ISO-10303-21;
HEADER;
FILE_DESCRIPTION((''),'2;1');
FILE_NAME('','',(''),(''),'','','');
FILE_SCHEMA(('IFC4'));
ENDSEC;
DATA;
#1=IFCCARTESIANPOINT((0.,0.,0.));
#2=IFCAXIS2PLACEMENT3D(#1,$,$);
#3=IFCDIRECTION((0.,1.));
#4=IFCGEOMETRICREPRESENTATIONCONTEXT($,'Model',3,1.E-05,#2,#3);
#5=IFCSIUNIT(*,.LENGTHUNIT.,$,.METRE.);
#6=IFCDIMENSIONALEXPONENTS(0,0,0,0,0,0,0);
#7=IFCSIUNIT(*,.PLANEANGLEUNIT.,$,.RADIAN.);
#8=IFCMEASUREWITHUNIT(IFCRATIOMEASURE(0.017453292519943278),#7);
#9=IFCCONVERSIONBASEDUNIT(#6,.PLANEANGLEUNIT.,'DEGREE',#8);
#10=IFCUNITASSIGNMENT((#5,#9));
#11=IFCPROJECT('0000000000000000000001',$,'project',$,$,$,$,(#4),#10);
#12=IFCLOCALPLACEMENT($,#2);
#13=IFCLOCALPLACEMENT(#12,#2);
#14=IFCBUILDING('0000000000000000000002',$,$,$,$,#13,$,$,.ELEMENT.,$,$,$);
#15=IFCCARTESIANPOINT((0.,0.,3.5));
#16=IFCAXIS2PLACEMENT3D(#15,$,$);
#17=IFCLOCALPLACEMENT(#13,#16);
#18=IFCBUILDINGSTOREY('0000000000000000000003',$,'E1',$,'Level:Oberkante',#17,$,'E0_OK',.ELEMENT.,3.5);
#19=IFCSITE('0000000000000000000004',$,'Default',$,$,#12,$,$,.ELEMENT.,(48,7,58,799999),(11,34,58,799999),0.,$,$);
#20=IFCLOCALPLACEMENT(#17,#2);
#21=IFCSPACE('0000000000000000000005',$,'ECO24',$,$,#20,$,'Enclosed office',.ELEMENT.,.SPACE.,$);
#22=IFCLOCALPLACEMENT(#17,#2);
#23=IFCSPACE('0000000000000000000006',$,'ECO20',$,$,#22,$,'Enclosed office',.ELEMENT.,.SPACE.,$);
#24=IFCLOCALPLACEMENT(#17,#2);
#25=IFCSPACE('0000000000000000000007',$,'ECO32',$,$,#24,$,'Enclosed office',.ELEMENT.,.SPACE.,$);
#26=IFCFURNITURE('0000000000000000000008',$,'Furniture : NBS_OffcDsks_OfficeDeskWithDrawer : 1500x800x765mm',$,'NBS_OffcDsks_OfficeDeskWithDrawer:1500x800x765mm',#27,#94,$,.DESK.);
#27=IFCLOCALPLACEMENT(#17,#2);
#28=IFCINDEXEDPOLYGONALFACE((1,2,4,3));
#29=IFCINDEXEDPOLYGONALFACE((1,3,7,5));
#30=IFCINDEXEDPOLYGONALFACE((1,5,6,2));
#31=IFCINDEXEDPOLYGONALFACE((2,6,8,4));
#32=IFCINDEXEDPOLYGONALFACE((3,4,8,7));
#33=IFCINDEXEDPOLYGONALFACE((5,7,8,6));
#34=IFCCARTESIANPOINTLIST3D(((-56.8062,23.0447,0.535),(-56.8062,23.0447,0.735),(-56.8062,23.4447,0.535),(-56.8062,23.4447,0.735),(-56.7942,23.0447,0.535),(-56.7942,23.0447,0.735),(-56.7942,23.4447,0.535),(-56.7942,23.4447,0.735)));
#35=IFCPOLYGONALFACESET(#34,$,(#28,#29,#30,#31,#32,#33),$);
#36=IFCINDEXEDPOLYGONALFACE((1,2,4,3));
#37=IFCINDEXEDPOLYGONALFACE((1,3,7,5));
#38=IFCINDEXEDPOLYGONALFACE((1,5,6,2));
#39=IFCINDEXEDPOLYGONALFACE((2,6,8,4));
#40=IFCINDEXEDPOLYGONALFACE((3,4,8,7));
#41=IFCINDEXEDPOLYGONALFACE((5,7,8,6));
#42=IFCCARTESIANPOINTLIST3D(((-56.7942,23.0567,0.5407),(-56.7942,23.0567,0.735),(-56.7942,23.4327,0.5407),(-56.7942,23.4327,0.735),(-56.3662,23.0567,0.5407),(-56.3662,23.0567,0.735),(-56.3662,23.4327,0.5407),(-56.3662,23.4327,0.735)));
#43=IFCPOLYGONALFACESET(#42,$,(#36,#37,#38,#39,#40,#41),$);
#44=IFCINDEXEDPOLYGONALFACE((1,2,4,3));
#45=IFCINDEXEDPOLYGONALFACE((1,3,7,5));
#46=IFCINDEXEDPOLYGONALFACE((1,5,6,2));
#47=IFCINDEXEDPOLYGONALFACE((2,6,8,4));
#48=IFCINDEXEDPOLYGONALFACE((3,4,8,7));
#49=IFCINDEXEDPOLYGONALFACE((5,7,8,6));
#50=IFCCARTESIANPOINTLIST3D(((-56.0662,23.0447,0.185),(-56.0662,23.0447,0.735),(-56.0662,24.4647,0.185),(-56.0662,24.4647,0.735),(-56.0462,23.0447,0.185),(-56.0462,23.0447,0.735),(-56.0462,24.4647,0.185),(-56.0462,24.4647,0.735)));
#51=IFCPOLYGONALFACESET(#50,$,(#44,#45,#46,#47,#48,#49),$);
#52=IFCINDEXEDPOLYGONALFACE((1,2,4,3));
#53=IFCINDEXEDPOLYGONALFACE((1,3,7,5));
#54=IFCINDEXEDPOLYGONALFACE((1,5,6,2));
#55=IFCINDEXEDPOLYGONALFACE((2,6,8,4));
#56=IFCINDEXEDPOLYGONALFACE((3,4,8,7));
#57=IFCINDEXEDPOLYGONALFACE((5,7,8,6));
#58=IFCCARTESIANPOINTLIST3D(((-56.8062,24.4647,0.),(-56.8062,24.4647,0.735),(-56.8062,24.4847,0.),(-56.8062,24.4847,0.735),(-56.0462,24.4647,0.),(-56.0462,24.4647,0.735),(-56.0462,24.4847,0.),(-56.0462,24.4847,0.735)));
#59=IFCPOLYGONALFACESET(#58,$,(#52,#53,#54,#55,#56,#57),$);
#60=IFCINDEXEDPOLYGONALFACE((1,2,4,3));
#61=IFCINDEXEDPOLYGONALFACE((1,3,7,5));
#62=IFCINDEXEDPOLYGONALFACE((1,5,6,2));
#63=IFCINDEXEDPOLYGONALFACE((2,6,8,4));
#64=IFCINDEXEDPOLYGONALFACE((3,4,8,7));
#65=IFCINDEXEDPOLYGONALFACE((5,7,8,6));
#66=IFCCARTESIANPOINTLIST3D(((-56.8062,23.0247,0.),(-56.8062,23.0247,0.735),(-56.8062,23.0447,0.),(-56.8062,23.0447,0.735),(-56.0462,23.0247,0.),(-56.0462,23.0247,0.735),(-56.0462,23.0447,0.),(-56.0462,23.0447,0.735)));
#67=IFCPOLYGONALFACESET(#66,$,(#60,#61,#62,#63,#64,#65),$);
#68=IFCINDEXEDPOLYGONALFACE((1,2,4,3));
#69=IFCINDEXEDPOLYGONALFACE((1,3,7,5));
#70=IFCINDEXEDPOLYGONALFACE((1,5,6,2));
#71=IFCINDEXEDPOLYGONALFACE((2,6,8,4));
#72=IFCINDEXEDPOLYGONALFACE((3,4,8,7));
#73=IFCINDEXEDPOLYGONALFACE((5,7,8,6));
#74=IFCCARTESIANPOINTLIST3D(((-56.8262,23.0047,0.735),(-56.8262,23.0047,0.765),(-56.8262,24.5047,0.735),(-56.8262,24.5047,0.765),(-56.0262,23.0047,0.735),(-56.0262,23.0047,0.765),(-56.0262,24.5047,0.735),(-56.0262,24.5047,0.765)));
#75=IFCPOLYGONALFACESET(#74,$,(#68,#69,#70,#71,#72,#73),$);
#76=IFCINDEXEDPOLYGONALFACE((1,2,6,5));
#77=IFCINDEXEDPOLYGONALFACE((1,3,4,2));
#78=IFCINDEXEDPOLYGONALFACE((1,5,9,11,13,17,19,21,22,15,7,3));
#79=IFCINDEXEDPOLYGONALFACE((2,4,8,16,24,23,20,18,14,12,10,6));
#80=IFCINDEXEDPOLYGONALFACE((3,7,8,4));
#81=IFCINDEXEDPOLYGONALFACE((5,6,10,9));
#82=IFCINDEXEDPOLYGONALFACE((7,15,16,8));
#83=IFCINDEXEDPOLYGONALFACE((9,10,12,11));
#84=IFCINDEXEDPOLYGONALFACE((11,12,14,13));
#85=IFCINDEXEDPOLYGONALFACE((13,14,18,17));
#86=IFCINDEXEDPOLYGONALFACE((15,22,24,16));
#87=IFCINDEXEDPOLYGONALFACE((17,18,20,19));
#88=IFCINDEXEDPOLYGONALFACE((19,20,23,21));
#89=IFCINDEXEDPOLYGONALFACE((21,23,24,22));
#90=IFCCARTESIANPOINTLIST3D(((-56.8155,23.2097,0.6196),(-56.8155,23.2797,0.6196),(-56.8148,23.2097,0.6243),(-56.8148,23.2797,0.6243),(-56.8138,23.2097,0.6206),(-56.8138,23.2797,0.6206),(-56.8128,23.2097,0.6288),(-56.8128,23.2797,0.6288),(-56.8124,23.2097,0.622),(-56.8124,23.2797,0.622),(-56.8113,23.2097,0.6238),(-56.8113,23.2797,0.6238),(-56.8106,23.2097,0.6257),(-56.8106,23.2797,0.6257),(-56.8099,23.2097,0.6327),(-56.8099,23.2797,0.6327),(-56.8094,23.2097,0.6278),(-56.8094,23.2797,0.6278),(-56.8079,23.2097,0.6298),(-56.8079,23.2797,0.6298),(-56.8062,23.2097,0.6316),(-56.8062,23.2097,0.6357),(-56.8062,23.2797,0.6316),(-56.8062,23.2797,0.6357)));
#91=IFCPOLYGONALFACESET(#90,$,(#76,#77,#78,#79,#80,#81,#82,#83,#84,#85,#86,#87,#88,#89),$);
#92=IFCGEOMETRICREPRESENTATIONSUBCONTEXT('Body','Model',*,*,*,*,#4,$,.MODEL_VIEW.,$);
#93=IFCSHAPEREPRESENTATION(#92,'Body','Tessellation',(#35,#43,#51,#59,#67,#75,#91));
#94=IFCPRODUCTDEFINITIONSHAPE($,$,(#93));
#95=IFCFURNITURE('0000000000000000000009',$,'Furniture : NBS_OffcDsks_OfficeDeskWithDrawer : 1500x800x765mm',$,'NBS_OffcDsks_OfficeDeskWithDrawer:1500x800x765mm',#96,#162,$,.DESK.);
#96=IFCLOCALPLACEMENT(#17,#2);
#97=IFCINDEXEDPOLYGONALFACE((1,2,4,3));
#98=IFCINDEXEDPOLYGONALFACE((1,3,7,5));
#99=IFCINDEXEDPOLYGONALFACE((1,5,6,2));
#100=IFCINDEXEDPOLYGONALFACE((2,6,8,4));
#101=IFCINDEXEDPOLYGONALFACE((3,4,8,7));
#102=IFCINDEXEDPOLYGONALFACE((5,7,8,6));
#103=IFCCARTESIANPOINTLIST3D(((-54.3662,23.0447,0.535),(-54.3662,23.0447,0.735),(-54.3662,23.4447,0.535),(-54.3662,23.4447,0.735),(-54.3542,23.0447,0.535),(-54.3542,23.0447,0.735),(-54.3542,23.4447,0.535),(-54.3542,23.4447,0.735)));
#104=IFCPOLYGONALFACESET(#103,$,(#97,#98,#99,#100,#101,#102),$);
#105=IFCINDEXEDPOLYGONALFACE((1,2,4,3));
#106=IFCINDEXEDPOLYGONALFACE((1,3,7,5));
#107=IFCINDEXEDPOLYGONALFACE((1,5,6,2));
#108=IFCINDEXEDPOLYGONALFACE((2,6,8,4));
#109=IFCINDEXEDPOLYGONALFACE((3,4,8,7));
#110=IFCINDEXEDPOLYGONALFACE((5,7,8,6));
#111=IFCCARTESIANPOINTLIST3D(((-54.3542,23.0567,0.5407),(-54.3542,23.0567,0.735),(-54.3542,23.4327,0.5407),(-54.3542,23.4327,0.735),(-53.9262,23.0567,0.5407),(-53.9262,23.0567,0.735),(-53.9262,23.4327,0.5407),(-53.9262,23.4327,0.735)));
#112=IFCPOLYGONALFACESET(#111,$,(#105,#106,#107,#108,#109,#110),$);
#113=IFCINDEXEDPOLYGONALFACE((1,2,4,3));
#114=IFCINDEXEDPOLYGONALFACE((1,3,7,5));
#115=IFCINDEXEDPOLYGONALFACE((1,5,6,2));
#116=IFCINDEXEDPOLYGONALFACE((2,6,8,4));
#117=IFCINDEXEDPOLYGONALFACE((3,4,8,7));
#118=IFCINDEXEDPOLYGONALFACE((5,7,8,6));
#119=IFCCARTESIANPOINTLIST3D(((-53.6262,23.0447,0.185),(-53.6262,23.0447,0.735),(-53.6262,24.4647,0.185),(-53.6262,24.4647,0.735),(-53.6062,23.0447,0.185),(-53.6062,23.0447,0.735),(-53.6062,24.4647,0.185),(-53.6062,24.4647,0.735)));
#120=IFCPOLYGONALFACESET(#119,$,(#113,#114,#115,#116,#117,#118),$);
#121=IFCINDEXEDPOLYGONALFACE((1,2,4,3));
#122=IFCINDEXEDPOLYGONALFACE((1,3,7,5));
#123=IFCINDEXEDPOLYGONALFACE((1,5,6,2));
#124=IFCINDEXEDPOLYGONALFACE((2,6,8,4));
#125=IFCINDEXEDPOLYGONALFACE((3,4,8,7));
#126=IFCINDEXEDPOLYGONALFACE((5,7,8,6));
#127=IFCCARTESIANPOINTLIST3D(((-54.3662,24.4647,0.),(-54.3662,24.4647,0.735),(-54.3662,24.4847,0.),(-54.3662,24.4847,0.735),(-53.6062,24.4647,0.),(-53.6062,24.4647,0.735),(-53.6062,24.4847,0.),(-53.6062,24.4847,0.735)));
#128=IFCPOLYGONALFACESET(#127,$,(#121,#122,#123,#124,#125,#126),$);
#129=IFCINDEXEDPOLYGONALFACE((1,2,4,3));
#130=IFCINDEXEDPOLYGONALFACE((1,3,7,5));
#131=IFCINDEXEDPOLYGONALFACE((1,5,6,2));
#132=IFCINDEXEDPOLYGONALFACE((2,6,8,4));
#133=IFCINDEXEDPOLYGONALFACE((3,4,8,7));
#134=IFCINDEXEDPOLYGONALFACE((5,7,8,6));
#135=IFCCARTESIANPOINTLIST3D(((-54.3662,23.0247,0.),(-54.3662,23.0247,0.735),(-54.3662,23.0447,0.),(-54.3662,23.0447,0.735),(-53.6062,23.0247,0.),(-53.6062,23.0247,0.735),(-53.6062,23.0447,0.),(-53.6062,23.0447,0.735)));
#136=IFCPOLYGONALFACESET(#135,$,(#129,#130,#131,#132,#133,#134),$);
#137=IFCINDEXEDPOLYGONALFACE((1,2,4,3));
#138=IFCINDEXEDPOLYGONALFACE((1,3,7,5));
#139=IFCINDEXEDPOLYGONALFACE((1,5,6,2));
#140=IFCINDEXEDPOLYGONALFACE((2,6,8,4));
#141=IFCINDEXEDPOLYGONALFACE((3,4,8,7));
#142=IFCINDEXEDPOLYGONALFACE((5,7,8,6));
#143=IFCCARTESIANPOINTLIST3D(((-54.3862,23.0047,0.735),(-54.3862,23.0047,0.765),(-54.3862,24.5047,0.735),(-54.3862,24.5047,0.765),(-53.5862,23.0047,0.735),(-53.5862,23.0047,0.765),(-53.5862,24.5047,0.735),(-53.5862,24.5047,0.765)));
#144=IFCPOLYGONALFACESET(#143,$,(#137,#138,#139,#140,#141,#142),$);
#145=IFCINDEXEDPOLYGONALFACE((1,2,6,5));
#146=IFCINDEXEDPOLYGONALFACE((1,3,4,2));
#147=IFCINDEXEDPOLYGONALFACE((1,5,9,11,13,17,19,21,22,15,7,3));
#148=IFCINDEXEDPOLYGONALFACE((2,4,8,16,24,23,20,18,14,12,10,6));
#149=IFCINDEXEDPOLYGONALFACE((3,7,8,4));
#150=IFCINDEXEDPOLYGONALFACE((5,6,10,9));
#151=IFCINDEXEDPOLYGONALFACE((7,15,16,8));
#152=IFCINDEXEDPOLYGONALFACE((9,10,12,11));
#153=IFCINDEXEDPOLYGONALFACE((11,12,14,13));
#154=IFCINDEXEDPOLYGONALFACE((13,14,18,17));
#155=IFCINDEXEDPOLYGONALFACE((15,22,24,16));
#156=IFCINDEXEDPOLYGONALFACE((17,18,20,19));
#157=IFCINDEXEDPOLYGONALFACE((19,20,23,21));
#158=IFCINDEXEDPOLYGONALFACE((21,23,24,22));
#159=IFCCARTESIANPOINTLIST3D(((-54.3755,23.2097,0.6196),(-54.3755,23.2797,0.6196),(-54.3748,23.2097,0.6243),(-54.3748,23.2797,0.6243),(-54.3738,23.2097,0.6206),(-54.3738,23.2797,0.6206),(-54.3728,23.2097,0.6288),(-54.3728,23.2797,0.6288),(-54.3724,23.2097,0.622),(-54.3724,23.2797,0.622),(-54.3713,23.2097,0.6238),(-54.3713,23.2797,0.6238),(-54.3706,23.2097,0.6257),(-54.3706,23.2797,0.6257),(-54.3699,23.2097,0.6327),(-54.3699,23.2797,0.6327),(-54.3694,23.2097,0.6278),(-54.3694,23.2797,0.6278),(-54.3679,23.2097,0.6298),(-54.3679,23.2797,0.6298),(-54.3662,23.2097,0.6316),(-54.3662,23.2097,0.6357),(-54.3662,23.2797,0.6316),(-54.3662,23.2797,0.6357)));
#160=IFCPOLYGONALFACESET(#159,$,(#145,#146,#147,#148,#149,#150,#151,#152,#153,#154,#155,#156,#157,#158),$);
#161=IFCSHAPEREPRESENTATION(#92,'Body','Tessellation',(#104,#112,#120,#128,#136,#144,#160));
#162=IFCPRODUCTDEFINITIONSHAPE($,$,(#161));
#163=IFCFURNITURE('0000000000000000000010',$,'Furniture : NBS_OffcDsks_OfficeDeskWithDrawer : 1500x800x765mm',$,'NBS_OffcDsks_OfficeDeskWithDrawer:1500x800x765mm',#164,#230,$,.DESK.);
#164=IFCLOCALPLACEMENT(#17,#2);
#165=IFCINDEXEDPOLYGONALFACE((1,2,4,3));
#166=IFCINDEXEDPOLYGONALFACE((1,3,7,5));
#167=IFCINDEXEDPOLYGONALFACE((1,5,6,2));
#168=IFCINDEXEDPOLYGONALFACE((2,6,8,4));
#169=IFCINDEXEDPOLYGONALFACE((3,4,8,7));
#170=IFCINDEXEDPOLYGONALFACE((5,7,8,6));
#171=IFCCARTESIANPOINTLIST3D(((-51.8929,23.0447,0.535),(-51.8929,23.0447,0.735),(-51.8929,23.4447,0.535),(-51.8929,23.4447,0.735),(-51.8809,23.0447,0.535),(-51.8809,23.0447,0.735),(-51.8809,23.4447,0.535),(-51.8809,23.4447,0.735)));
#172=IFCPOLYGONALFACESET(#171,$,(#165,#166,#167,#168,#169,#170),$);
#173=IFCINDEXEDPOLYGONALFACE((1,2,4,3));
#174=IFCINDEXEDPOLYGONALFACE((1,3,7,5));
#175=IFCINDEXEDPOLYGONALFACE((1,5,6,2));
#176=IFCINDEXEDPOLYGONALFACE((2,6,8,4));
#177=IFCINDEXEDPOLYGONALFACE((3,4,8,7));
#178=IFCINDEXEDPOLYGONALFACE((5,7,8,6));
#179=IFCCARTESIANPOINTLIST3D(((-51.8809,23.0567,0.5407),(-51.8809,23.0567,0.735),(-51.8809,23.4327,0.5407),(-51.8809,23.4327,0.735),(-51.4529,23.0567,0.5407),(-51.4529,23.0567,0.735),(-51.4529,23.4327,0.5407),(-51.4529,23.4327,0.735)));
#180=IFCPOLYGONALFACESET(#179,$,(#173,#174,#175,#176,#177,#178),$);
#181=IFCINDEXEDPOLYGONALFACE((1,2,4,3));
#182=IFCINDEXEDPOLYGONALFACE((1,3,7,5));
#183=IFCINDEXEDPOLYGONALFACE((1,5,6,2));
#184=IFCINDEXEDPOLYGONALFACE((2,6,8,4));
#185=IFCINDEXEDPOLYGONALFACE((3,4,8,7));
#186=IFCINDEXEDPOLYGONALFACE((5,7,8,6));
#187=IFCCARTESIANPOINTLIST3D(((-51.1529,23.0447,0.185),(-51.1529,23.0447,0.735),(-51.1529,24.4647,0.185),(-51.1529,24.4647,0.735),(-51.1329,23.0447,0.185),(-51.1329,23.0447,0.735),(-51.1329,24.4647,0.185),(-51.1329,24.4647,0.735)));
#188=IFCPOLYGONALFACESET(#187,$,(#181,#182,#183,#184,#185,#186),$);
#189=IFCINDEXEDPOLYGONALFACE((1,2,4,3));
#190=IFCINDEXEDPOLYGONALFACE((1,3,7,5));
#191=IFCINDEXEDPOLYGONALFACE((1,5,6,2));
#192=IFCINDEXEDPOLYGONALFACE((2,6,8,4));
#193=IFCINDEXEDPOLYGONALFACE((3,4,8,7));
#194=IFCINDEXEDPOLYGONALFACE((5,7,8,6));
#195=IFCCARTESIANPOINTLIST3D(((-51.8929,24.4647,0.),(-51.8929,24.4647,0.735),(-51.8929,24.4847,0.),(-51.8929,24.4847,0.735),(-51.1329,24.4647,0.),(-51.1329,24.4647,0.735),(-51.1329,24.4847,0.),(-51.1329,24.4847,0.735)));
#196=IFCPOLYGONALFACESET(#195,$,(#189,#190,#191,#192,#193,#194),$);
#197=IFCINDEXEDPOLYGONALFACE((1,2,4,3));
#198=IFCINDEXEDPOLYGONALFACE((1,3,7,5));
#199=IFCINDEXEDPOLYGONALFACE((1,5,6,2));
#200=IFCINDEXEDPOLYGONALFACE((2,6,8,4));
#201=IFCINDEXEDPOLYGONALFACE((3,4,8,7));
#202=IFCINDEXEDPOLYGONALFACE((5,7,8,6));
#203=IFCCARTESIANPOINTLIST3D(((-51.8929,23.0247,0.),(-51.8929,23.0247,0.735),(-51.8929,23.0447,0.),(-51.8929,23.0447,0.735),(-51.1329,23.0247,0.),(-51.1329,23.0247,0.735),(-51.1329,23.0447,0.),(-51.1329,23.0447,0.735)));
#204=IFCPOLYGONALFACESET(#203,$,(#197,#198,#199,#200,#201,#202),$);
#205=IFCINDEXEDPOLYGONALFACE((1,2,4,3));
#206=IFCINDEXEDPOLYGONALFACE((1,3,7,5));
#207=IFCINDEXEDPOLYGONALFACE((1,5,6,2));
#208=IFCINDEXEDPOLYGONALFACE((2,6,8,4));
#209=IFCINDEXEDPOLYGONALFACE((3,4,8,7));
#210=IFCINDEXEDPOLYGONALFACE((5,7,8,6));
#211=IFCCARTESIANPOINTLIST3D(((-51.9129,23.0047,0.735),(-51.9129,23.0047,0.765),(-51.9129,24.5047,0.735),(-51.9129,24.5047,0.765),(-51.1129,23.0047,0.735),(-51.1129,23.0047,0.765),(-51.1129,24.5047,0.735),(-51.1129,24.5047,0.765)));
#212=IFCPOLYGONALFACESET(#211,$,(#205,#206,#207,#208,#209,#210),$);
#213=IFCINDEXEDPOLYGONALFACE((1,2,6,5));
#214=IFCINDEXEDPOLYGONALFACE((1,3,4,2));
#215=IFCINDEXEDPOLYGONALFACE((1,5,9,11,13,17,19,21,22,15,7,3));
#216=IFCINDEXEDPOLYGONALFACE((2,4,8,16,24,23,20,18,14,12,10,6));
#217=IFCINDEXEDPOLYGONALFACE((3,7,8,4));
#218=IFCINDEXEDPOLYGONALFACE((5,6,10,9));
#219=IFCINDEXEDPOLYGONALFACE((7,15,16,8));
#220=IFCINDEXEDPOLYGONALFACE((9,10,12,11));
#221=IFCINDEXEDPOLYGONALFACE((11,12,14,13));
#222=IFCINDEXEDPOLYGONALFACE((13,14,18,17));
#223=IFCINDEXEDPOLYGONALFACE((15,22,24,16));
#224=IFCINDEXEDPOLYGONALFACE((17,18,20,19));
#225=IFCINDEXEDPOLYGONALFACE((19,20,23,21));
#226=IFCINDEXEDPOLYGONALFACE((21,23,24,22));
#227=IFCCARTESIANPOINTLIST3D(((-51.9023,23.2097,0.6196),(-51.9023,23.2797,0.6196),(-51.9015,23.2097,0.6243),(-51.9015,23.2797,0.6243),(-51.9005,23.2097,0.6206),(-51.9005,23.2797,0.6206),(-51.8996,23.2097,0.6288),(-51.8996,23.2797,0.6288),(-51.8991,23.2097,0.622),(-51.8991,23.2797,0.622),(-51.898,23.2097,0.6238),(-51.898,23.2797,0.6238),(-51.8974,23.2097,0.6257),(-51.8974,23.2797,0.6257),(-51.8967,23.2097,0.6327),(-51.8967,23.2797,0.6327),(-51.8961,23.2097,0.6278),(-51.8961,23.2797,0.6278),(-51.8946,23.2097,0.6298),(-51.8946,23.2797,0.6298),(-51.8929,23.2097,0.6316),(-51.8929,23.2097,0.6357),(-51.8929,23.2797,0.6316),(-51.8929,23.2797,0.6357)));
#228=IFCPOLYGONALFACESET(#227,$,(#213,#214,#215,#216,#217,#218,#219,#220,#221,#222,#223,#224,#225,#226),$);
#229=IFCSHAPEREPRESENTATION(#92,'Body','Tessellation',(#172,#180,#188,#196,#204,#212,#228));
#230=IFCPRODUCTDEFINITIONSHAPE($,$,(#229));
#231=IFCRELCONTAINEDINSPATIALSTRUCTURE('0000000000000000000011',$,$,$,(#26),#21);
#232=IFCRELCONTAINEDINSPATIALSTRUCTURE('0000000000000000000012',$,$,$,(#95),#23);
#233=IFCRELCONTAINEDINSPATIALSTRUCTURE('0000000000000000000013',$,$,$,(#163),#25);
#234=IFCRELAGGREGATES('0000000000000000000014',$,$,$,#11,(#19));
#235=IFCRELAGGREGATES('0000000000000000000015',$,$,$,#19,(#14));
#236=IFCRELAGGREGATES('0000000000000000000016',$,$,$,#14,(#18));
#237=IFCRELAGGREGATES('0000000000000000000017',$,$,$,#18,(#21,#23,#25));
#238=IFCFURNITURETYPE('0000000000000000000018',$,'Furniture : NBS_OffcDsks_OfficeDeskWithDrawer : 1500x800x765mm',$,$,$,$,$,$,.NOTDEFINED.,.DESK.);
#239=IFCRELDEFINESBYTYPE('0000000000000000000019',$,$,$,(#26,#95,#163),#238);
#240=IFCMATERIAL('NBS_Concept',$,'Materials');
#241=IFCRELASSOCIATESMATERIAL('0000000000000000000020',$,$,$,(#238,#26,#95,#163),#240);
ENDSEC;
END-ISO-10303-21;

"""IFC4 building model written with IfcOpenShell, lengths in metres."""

from ifc_helpers import new_model, entity, si_unit, converted_unit, direction, frame, origin, place, context, subcontext, project, spatial, line, arc, indexed_curve, outline, extrude, source, transform, mapped, material, type_object, type_shapes, element, save


model = new_model("IFC4")

# Units and contexts
model_context = context("Model", 3, precision=1e-05, world=origin(), true_north=direction((0.0, 1.0)))
body_context = subcontext(model_context, "Body", "Model", "MODEL_VIEW")
ifc_project = project(units=[si_unit("LENGTHUNIT", "METRE"), converted_unit("PLANEANGLEUNIT", "DEGREE", entity("IfcRatioMeasure", 0.017453292519943278), si_unit("PLANEANGLEUNIT", "RADIAN"), dimensions=[0, 0, 0, 0, 0, 0, 0])], contexts=[model_context])

# Site, building, storey
site_placement = place(None, origin())
site = spatial("IfcSite", under=ifc_project, at=site_placement, Name="Default", CompositionType="ELEMENT", RefLatitude=(48, 7, 58, 799999), RefLongitude=(11, 34, 58, 799999), RefElevation=0.0)
building_placement = place(site_placement, origin())
building = spatial("IfcBuilding", under=site, at=building_placement, CompositionType="ELEMENT")
storey_placement = place(building_placement, frame((0.0, 0.0, 3.5)))
storey = spatial("IfcBuildingStorey", under=building, at=storey_placement, Name="E1", ObjectType="Level:Oberkante", LongName="E0_OK", CompositionType="ELEMENT", Elevation=3.5)

# Shared definitions
space_1_placement = place(storey_placement, origin())
space_1 = spatial("IfcSpace", under=storey, at=space_1_placement, Name="ECO24", LongName="Enclosed office", CompositionType="ELEMENT", PredefinedType="SPACE")

# Furniture
ifc_material_1 = material(Name="NBS_Concept", Category="Materials")
furniture_type = type_object("IfcFurnitureType", Name="Furniture : NBS_OffcDsks_OfficeDeskWithDrawer : 1500x800x765mm", AssemblyPlace="NOTDEFINED", PredefinedType="DESK", material=ifc_material_1)
shared_shape = source(origin(), body_context, "Body", "SweptSolid", [
    extrude(outline(indexed_curve([(-0.006, -0.2), (0.006, -0.2), (0.006, 0.2), (-0.006, 0.2), (-0.006, -0.2)], self_intersect=False)), frame((0.51, -0.374, 0.535), z_axis=(0.0, 0.0, 1.0), x_axis=(0.0, 1.0, 0.0)), (0.0, 0.0, 1.0), 0.2),
    extrude(outline(indexed_curve([(-0.188, -0.214), (0.188, -0.214), (0.188, 0.214), (-0.188, 0.214), (-0.188, -0.214)], self_intersect=False)), frame((0.51, -0.154, 0.5407), z_axis=(0.0, 0.0, 1.0), x_axis=(-1.0, 0.0, 0.0)), (0.0, 0.0, 1.0), 0.1943),
    extrude(outline(indexed_curve([(-0.71, -0.01), (0.71, -0.01), (0.71, 0.01), (-0.71, 0.01), (-0.71, -0.01)], self_intersect=False)), frame((0.0, 0.37, 0.185), z_axis=(0.0, 0.0, 1.0), x_axis=(-1.0, 0.0, 0.0)), (0.0, 0.0, 1.0), 0.55),
    extrude(outline(indexed_curve([(-0.01, -0.38), (0.01, -0.38), (0.01, 0.38), (-0.01, 0.38), (-0.01, -0.38)], self_intersect=False)), frame((-0.72, 0.0, 0.0), z_axis=(0.0, 0.0, 1.0), x_axis=(-1.0, 0.0, 0.0)), (0.0, 0.0, 1.0), 0.735),
    extrude(outline(indexed_curve([(-0.01, -0.38), (0.01, -0.38), (0.01, 0.38), (-0.01, 0.38), (-0.01, -0.38)], self_intersect=False)), frame((0.72, 0.0, 0.0), z_axis=(0.0, 0.0, 1.0), x_axis=(-1.0, 0.0, 0.0)), (0.0, 0.0, 1.0), 0.735),
    extrude(outline(indexed_curve([(-0.75, -0.4), (0.75, -0.4), (0.75, 0.4), (-0.75, 0.4), (-0.75, -0.4)], self_intersect=False)), frame((0.0, 0.0, 0.735), z_axis=(0.0, 0.0, 1.0), x_axis=(-1.0, 0.0, 0.0)), (0.0, 0.0, 1.0), 0.03),
    extrude(outline(indexed_curve([(0.0086, -0.0059), (0.0061, -0.0027), (0.0025, -0.001), (-0.0007, 0.0009), (-0.0034, 0.0035), (-0.0076, 0.0035), (-0.0007, -0.0032)], segments=[arc(1, 2, 3), arc(3, 4, 5), line(5, 6), arc(6, 7, 1)], self_intersect=False)), frame((0.475, -0.3835, 0.6281), z_axis=(1.0, 0.0, 0.0), x_axis=(0.0, 0.0, -1.0)), (0.0, 0.0, 1.0), 0.07),
])
type_shapes(furniture_type, [shared_shape])
furniture_1_placement = place(space_1_placement, frame((-56.4262, 23.7547, 0.0), z_axis=(0.0, 0.0, 1.0), x_axis=(0.0, -1.0, 0.0)))
element("IfcFurniture", 1, at=furniture_1_placement, inside=space_1, type_object=furniture_type, material=ifc_material_1, Name="Furniture : NBS_OffcDsks_OfficeDeskWithDrawer : 1500x800x765mm", ObjectType="NBS_OffcDsks_OfficeDeskWithDrawer:1500x800x765mm", PredefinedType="DESK", context=body_context, shape_type="MappedRepresentation", body=[
    mapped(shared_shape, transform((0.0, 0.0, 0.0), scale=1.0)),
])

# Shared definitions
space_2_placement = place(storey_placement, origin())
space_2 = spatial("IfcSpace", under=storey, at=space_2_placement, Name="ECO20", LongName="Enclosed office", CompositionType="ELEMENT", PredefinedType="SPACE")

# Furniture
furniture_2_placement = place(space_2_placement, frame((-53.9862, 23.7547, 0.0), z_axis=(0.0, 0.0, 1.0), x_axis=(0.0, -1.0, 0.0)))
element("IfcFurniture", 2, at=furniture_2_placement, inside=space_2, type_object=furniture_type, material=ifc_material_1, Name="Furniture : NBS_OffcDsks_OfficeDeskWithDrawer : 1500x800x765mm", ObjectType="NBS_OffcDsks_OfficeDeskWithDrawer:1500x800x765mm", PredefinedType="DESK", context=body_context, shape_type="MappedRepresentation", body=[
    mapped(shared_shape, transform((0.0, 0.0, 0.0), scale=1.0)),
])

# Shared definitions
space_3_placement = place(storey_placement, origin())
space_3 = spatial("IfcSpace", under=storey, at=space_3_placement, Name="ECO32", LongName="Enclosed office", CompositionType="ELEMENT", PredefinedType="SPACE")

# Furniture
furniture_3_placement = place(space_3_placement, frame((-51.5129, 23.7547, 0.0), z_axis=(0.0, 0.0, 1.0), x_axis=(0.0, -1.0, 0.0)))
element("IfcFurniture", 3, at=furniture_3_placement, inside=space_3, type_object=furniture_type, material=ifc_material_1, Name="Furniture : NBS_OffcDsks_OfficeDeskWithDrawer : 1500x800x765mm", ObjectType="NBS_OffcDsks_OfficeDeskWithDrawer:1500x800x765mm", PredefinedType="DESK", context=body_context, shape_type="MappedRepresentation", body=[
    mapped(shared_shape, transform((0.0, 0.0, 0.0), scale=1.0)),
])

save(model, "model.ifc")
